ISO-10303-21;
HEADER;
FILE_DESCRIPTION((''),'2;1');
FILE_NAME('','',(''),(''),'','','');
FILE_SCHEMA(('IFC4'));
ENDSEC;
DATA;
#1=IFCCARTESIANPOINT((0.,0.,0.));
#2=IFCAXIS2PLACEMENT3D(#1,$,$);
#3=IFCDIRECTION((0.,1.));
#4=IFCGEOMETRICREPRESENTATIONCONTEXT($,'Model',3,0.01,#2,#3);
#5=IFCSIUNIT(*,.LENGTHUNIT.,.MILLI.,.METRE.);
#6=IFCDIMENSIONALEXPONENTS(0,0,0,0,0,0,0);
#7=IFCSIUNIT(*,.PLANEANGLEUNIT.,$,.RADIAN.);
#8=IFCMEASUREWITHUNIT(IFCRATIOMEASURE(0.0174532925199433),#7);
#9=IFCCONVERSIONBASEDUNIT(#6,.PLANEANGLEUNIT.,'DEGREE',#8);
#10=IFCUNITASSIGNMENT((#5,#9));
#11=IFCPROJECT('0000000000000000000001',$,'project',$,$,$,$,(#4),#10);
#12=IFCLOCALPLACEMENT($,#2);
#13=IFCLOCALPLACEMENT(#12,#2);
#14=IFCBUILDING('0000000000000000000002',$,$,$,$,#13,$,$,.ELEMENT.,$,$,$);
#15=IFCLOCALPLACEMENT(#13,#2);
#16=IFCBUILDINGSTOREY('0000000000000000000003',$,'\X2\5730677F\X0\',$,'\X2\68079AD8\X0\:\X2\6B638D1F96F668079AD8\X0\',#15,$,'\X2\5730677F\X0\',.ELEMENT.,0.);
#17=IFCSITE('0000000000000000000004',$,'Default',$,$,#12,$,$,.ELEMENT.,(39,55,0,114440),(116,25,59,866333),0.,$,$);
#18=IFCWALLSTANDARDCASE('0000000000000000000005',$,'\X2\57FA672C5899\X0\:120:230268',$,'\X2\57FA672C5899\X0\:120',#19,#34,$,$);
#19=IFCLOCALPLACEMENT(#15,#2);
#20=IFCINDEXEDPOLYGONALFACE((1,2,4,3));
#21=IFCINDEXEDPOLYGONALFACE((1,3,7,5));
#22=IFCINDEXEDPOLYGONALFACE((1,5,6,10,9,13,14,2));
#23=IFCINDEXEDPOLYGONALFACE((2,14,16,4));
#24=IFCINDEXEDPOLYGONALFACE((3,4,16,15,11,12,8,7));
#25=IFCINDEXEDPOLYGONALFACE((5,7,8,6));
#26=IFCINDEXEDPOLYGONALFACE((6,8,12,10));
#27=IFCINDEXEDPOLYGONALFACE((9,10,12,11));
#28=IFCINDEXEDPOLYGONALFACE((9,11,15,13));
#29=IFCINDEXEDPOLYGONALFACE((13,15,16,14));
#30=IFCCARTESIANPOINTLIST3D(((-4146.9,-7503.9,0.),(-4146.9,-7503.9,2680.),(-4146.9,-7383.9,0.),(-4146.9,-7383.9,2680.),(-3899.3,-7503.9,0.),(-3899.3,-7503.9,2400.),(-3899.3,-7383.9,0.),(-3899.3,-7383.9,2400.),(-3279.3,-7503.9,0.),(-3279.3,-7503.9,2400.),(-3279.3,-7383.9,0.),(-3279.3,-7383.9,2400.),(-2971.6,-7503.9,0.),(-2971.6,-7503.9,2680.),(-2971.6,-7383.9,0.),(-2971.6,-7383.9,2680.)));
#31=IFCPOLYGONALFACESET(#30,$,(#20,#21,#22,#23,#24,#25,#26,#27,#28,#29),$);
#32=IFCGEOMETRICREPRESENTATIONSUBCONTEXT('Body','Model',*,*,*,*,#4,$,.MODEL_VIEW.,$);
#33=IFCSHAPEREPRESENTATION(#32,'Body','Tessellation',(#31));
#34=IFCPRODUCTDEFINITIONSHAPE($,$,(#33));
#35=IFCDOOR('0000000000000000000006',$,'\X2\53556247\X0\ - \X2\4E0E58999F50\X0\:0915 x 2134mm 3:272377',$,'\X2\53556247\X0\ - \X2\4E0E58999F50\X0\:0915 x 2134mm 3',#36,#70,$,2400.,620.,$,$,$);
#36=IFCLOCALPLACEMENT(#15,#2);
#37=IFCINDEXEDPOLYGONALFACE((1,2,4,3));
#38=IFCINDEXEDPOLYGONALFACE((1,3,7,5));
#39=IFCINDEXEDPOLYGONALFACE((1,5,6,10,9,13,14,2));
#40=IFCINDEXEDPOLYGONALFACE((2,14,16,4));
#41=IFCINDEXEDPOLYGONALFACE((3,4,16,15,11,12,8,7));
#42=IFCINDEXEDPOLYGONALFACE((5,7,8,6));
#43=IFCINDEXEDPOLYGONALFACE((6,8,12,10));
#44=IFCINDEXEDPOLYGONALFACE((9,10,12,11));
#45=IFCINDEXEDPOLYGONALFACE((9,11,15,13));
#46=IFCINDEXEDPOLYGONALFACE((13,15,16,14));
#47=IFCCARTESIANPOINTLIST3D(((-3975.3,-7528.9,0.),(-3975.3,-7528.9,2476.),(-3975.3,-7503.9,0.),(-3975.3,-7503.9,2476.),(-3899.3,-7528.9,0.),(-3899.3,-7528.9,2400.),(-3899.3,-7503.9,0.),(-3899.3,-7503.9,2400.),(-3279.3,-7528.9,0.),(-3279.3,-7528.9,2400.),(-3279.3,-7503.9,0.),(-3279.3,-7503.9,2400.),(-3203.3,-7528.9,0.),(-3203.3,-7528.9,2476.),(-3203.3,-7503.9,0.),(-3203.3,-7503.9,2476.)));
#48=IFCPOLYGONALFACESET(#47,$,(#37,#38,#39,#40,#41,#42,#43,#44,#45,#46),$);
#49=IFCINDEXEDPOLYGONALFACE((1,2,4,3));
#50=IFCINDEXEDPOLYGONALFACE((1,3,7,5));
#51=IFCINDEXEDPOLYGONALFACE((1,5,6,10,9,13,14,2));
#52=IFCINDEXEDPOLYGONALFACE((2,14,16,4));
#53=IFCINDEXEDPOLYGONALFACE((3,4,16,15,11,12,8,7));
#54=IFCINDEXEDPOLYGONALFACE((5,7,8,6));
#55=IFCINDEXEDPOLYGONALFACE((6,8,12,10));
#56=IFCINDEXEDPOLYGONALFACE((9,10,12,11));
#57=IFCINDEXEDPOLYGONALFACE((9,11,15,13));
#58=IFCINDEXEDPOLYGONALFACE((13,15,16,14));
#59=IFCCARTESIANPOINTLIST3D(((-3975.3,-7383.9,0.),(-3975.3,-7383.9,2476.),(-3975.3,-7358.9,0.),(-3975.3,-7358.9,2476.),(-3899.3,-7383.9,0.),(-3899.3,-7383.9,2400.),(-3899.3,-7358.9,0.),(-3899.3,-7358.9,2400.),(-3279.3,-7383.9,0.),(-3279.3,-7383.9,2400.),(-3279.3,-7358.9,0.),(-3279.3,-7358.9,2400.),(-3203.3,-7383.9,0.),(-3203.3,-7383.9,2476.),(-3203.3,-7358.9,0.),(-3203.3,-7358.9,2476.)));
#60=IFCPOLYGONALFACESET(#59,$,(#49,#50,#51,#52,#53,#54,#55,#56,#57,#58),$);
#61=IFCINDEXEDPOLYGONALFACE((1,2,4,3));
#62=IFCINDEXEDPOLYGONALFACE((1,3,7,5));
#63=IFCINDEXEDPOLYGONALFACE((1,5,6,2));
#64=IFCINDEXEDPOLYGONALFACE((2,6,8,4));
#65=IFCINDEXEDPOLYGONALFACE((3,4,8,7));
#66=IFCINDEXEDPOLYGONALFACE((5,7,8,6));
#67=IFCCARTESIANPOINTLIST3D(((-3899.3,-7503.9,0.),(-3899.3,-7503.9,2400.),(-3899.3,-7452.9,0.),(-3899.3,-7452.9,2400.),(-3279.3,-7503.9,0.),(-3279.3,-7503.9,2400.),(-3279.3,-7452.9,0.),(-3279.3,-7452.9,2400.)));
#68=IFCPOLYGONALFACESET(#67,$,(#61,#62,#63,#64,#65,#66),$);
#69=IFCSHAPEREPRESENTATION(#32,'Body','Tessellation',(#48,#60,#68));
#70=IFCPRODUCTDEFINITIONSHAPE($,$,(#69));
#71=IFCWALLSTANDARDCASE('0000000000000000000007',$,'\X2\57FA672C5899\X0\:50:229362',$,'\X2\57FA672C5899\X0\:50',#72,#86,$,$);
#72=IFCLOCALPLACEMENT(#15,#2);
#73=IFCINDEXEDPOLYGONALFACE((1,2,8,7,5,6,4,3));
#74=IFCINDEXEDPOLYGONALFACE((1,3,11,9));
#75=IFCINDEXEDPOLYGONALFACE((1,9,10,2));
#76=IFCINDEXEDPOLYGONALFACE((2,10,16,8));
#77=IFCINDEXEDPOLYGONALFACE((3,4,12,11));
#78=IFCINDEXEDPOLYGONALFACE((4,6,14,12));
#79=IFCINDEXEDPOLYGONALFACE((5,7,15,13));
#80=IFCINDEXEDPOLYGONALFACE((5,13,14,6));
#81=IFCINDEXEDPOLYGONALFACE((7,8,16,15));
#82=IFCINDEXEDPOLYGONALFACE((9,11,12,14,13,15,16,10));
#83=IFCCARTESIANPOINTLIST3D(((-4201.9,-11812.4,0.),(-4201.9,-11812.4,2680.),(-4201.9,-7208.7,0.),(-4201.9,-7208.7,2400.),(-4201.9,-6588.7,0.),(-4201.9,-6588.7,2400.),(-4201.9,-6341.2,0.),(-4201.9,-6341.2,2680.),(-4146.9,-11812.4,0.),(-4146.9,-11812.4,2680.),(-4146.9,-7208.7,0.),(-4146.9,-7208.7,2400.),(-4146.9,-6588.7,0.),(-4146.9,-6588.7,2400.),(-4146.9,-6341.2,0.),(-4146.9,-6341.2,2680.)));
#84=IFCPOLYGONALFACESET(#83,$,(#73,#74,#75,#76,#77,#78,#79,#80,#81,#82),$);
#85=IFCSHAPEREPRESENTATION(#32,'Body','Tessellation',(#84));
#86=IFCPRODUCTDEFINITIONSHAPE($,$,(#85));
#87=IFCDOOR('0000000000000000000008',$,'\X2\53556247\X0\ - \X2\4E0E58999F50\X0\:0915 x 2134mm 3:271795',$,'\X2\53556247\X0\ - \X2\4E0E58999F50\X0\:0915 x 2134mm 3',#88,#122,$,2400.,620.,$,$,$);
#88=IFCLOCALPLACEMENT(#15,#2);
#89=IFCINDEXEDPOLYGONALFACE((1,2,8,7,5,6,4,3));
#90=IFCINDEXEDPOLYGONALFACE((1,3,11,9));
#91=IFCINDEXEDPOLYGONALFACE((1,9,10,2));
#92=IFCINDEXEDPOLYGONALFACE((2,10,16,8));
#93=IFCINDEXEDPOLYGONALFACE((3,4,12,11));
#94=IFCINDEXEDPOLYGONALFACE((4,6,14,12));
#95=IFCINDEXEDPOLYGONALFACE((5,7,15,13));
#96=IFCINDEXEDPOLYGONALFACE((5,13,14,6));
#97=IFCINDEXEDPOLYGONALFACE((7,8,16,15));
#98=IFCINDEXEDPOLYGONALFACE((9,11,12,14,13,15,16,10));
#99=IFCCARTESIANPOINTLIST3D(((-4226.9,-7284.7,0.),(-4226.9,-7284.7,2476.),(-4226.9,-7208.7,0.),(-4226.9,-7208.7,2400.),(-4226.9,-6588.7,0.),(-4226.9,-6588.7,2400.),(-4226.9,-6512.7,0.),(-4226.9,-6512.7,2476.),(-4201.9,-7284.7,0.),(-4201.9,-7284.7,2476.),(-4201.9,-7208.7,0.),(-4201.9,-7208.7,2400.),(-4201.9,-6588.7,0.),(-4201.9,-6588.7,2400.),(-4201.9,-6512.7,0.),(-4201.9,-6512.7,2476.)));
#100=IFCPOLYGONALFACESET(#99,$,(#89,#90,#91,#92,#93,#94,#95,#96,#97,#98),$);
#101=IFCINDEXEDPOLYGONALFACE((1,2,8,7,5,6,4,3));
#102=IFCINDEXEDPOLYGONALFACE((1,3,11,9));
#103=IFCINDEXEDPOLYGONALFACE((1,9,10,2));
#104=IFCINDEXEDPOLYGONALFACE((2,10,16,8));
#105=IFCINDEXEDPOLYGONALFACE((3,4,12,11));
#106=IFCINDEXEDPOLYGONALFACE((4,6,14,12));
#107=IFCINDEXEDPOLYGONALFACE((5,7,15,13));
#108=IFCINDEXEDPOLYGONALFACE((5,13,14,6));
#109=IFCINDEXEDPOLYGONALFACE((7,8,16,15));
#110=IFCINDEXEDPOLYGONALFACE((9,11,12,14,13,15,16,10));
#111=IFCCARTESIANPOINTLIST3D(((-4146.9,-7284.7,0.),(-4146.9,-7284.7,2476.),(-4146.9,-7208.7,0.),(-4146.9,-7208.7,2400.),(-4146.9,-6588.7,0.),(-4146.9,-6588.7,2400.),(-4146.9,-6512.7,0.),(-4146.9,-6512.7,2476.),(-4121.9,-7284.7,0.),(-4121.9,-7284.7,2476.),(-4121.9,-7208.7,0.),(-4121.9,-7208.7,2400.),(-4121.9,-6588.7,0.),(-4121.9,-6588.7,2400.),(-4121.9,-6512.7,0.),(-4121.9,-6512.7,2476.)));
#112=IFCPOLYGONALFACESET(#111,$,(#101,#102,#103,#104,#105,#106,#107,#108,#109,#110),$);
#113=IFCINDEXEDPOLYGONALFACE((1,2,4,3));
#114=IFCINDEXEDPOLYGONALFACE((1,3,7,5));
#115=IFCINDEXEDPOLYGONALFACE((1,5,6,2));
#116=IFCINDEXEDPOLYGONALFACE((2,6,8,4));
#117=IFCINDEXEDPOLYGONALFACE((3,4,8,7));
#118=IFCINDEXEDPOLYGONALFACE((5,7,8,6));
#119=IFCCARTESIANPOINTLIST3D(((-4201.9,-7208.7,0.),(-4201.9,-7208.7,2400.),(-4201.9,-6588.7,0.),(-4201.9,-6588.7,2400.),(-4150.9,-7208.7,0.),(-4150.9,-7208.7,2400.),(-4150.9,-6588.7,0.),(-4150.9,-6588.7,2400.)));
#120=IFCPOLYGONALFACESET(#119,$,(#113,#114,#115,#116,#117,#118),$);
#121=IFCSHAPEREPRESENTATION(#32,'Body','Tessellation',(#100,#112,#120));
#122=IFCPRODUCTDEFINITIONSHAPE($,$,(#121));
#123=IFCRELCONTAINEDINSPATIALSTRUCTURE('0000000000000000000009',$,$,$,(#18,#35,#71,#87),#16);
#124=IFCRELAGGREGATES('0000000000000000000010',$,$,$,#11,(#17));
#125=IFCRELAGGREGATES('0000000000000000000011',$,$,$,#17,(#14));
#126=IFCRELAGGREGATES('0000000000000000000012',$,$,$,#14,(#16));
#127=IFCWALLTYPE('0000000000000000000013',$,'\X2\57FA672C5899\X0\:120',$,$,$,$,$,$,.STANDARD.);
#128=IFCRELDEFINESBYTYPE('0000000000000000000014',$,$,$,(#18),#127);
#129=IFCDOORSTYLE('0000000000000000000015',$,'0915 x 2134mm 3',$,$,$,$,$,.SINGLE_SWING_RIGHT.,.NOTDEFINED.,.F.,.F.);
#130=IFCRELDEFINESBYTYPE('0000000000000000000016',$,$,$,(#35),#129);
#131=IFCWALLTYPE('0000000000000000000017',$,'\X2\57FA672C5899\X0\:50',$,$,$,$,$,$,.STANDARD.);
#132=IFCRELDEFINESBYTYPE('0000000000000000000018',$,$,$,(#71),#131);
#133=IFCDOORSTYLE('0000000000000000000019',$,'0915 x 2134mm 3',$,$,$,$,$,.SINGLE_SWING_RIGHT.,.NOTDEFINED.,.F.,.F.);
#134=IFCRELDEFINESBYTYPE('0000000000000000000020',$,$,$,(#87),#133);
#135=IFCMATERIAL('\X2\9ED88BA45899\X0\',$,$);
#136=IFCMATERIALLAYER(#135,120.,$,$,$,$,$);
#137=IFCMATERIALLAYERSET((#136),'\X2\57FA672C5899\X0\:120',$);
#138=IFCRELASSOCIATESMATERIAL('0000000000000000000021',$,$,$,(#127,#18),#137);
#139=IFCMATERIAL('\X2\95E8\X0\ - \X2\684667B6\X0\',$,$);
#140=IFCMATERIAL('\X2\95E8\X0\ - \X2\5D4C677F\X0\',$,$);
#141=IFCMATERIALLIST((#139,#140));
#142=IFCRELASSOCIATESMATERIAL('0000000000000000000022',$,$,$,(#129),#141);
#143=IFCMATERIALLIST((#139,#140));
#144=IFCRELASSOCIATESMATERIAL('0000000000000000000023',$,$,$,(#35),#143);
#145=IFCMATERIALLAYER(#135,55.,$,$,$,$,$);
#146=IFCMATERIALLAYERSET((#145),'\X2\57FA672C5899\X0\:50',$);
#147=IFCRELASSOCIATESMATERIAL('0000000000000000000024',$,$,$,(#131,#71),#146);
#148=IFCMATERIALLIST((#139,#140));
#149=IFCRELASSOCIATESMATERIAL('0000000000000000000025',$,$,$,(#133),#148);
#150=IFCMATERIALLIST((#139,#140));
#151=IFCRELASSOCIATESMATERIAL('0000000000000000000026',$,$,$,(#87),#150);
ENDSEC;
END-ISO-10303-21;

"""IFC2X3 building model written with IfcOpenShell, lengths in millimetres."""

from ifc_helpers import new_model, entity, si_unit, converted_unit, direction, frame, frame_2d, origin, origin_2d_with_axis, place, context, subcontext, project, spatial, polyline, rectangle, outline, extrude, source, transform, mapped, material, material_list, layer, layer_set, layer_usage, type_object, type_shapes, element, fill, save


model = new_model("IFC2X3")

# Units and contexts
model_context = context("Model", 3, precision=0.01, world=origin(), true_north=direction((0.0, 1.0)))
body_context = subcontext(model_context, "Body", "Model", "MODEL_VIEW")
ifc_project = project(units=[si_unit("LENGTHUNIT", "METRE", prefix="MILLI"), converted_unit("PLANEANGLEUNIT", "DEGREE", entity("IfcRatioMeasure", 0.0174532925199433), si_unit("PLANEANGLEUNIT", "RADIAN"), dimensions=[0, 0, 0, 0, 0, 0, 0])], contexts=[model_context])

# Site, building, storey
site_placement = place(None, origin())
site = spatial("IfcSite", under=ifc_project, at=site_placement, Name="Default", CompositionType="ELEMENT", RefLatitude=(39, 55, 0, 114440), RefLongitude=(116, 25, 59, 866333), RefElevation=0.0)
building_placement = place(site_placement, origin())
building = spatial("IfcBuilding", under=site, at=building_placement, CompositionType="ELEMENT")
storey_placement = place(building_placement, origin())
storey = spatial("IfcBuildingStorey", under=building, at=storey_placement, Name="地板", ObjectType="标高:正负零标高", LongName="地板", CompositionType="ELEMENT", Elevation=0.0)

# Shared definitions
ifc_material_1 = material(Name="默认墙")

# Shared definitions
ifc_material_2 = material(Name="门 - 框架")
ifc_material_3 = material(Name="门 - 嵌板")

# Walls, openings, doors
ifc_layer_1 = layer(ifc_material_1, 120.0)
ifc_layer_set_1 = layer_set([ifc_layer_1], Name="基本墙:120")
ifc_layer_usage_1 = layer_usage(ifc_layer_set_1, "AXIS2", "NEGATIVE", 60.0)
wall_type_1 = type_object("IfcWallType", Name="基本墙:120", PredefinedType="STANDARD", material=ifc_layer_set_1)
wall_1_placement = place(storey_placement, frame((-4146.9, -7443.9, 0.0)))
wall_1 = element("IfcWallStandardCase", 1, at=wall_1_placement, inside=storey, type_object=wall_type_1, material=ifc_layer_usage_1, Name="基本墙:120:230268", ObjectType="基本墙:120", context=body_context, shape_type="SweptSolid", body=[
    extrude(rectangle(XDim=1175.3, YDim=120.0, at=frame_2d((587.7, 0.0), x_axis=(-1.0, 0.0))), origin(), (0.0, 0.0, 1.0), 2680.0),
])
opening_1_placement = place(wall_1_placement, frame((867.7, 60.0, 0.0)))
opening_1 = element("IfcOpeningElement", 2, at=opening_1_placement, cuts=wall_1, ObjectType="Opening", context=body_context, shape_type="SweptSolid", body=[
    extrude(rectangle(XDim=620.0, YDim=2400.0, at=frame_2d((1200.0, 310.0), x_axis=(0.0, 1.0))), frame((0.0, 0.0, 0.0), z_axis=(0.0, -1.0, 0.0), x_axis=(0.0, 0.0, 1.0)), (0.0, 0.0, 1.0), 120.0),
])
ifc_material_list_1 = material_list([ifc_material_2, ifc_material_3])
ifc_material_list_2 = material_list([ifc_material_2, ifc_material_3])
door_style_1 = type_object("IfcDoorStyle", Name="0915 x 2134mm 3", ConstructionType="NOTDEFINED", OperationType="SINGLE_SWING_RIGHT", ParameterTakesPrecedence=False, Sizeable=False, material=ifc_material_list_2)
shared_shape_1 = source(origin(), body_context, "Body", "SweptSolid", [
    extrude(outline(polyline([(-386.0, -1257.0), (386.0, -1257.0), (386.0, 1219.0), (310.0, 1219.0), (310.0, -1181.0), (-310.0, -1181.0), (-310.0, 1219.0), (-386.0, 1219.0), (-386.0, -1257.0)])), frame((310.0, 120.0, 1219.0), z_axis=(0.0, 1.0, 0.0), x_axis=(1.0, 0.0, 0.0)), (0.0, 0.0, 1.0), 25.0),
    extrude(outline(polyline([(-1257.0, -386.0), (1219.0, -386.0), (1219.0, -310.0), (-1181.0, -310.0), (-1181.0, 310.0), (1219.0, 310.0), (1219.0, 386.0), (-1257.0, 386.0), (-1257.0, -386.0)])), frame((310.0, -25.0, 1219.0), z_axis=(0.0, 1.0, 0.0), x_axis=(0.0, 0.0, -1.0)), (0.0, 0.0, 1.0), 25.0),
    extrude(rectangle(XDim=51.0, YDim=620.0, at=origin_2d_with_axis()), frame((310.0, 94.5, 0.0), z_axis=(0.0, 0.0, 1.0), x_axis=(0.0, 1.0, 0.0)), (0.0, 0.0, 1.0), 2400.0),
])
type_shapes(door_style_1, [shared_shape_1])
door_1_placement = place(opening_1_placement, frame((0.0, 0.0, 0.0), z_axis=(0.0, 0.0, 1.0), x_axis=(-1.0, 0.0, 0.0)))
door_1 = element("IfcDoor", 3, at=door_1_placement, inside=storey, type_object=door_style_1, material=ifc_material_list_1, Name="单扇 - 与墙齐:0915 x 2134mm 3:272377", ObjectType="单扇 - 与墙齐:0915 x 2134mm 3", OverallHeight=2400.0, OverallWidth=620.0, context=body_context, shape_type="MappedRepresentation", body=[
    mapped(shared_shape_1, transform((0.0, 0.0, 0.0), scale=1.0)),
])
fill(opening_1, door_1)
ifc_layer_2 = layer(ifc_material_1, 55.0)
ifc_layer_set_2 = layer_set([ifc_layer_2], Name="基本墙:50")
ifc_layer_usage_2 = layer_usage(ifc_layer_set_2, "AXIS2", "NEGATIVE", 27.5)
wall_type_2 = type_object("IfcWallType", Name="基本墙:50", PredefinedType="STANDARD", material=ifc_layer_set_2)
wall_2_placement = place(storey_placement, frame((-4174.4, -11812.4, 0.0), z_axis=(0.0, 0.0, 1.0), x_axis=(0.0, 1.0, 0.0)))
wall_2 = element("IfcWallStandardCase", 4, at=wall_2_placement, inside=storey, type_object=wall_type_2, material=ifc_layer_usage_2, Name="基本墙:50:229362", ObjectType="基本墙:50", context=body_context, shape_type="SweptSolid", body=[
    extrude(rectangle(XDim=5471.2, YDim=55.0, at=frame_2d((2735.6, 0.0), x_axis=(-1.0, 0.0))), origin(), (0.0, 0.0, 1.0), 2680.0),
])
opening_2_placement = place(wall_2_placement, frame((4603.7, -27.5, 0.0)))
opening_2 = element("IfcOpeningElement", 5, at=opening_2_placement, cuts=wall_2, ObjectType="Opening", context=body_context, shape_type="SweptSolid", body=[
    extrude(rectangle(XDim=620.0, YDim=2400.0, at=frame_2d((1200.0, 310.0), x_axis=(0.0, 1.0))), frame((0.0, 0.0, 0.0), z_axis=(0.0, 1.0, 0.0), x_axis=(0.0, 0.0, 1.0)), (0.0, 0.0, 1.0), 55.0),
])
ifc_material_list_3 = material_list([ifc_material_2, ifc_material_3])
ifc_material_list_4 = material_list([ifc_material_2, ifc_material_3])
door_style_2 = type_object("IfcDoorStyle", Name="0915 x 2134mm 3", ConstructionType="NOTDEFINED", OperationType="SINGLE_SWING_RIGHT", ParameterTakesPrecedence=False, Sizeable=False, material=ifc_material_list_4)
shared_shape_2 = source(origin(), body_context, "Body", "SweptSolid", [
    extrude(outline(polyline([(-386.0, -1257.0), (386.0, -1257.0), (386.0, 1219.0), (310.0, 1219.0), (310.0, -1181.0), (-310.0, -1181.0), (-310.0, 1219.0), (-386.0, 1219.0), (-386.0, -1257.0)])), frame((310.0, 55.0, 1219.0), z_axis=(0.0, 1.0, 0.0), x_axis=(1.0, 0.0, 0.0)), (0.0, 0.0, 1.0), 25.0),
    extrude(outline(polyline([(-1257.0, -386.0), (1219.0, -386.0), (1219.0, -310.0), (-1181.0, -310.0), (-1181.0, 310.0), (1219.0, 310.0), (1219.0, 386.0), (-1257.0, 386.0), (-1257.0, -386.0)])), frame((310.0, -25.0, 1219.0), z_axis=(0.0, 1.0, 0.0), x_axis=(0.0, 0.0, -1.0)), (0.0, 0.0, 1.0), 25.0),
    extrude(rectangle(XDim=51.0, YDim=620.0, at=origin_2d_with_axis()), frame((310.0, 29.5, 0.0), z_axis=(0.0, 0.0, 1.0), x_axis=(0.0, 1.0, 0.0)), (0.0, 0.0, 1.0), 2400.0),
])
type_shapes(door_style_2, [shared_shape_2])
door_2_placement = place(opening_2_placement, origin())
door_2 = element("IfcDoor", 6, at=door_2_placement, inside=storey, type_object=door_style_2, material=ifc_material_list_3, Name="单扇 - 与墙齐:0915 x 2134mm 3:271795", ObjectType="单扇 - 与墙齐:0915 x 2134mm 3", OverallHeight=2400.0, OverallWidth=620.0, context=body_context, shape_type="MappedRepresentation", body=[
    mapped(shared_shape_2, transform((0.0, 0.0, 0.0), scale=1.0)),
])
fill(opening_2, door_2)

save(model, "model.ifc")
